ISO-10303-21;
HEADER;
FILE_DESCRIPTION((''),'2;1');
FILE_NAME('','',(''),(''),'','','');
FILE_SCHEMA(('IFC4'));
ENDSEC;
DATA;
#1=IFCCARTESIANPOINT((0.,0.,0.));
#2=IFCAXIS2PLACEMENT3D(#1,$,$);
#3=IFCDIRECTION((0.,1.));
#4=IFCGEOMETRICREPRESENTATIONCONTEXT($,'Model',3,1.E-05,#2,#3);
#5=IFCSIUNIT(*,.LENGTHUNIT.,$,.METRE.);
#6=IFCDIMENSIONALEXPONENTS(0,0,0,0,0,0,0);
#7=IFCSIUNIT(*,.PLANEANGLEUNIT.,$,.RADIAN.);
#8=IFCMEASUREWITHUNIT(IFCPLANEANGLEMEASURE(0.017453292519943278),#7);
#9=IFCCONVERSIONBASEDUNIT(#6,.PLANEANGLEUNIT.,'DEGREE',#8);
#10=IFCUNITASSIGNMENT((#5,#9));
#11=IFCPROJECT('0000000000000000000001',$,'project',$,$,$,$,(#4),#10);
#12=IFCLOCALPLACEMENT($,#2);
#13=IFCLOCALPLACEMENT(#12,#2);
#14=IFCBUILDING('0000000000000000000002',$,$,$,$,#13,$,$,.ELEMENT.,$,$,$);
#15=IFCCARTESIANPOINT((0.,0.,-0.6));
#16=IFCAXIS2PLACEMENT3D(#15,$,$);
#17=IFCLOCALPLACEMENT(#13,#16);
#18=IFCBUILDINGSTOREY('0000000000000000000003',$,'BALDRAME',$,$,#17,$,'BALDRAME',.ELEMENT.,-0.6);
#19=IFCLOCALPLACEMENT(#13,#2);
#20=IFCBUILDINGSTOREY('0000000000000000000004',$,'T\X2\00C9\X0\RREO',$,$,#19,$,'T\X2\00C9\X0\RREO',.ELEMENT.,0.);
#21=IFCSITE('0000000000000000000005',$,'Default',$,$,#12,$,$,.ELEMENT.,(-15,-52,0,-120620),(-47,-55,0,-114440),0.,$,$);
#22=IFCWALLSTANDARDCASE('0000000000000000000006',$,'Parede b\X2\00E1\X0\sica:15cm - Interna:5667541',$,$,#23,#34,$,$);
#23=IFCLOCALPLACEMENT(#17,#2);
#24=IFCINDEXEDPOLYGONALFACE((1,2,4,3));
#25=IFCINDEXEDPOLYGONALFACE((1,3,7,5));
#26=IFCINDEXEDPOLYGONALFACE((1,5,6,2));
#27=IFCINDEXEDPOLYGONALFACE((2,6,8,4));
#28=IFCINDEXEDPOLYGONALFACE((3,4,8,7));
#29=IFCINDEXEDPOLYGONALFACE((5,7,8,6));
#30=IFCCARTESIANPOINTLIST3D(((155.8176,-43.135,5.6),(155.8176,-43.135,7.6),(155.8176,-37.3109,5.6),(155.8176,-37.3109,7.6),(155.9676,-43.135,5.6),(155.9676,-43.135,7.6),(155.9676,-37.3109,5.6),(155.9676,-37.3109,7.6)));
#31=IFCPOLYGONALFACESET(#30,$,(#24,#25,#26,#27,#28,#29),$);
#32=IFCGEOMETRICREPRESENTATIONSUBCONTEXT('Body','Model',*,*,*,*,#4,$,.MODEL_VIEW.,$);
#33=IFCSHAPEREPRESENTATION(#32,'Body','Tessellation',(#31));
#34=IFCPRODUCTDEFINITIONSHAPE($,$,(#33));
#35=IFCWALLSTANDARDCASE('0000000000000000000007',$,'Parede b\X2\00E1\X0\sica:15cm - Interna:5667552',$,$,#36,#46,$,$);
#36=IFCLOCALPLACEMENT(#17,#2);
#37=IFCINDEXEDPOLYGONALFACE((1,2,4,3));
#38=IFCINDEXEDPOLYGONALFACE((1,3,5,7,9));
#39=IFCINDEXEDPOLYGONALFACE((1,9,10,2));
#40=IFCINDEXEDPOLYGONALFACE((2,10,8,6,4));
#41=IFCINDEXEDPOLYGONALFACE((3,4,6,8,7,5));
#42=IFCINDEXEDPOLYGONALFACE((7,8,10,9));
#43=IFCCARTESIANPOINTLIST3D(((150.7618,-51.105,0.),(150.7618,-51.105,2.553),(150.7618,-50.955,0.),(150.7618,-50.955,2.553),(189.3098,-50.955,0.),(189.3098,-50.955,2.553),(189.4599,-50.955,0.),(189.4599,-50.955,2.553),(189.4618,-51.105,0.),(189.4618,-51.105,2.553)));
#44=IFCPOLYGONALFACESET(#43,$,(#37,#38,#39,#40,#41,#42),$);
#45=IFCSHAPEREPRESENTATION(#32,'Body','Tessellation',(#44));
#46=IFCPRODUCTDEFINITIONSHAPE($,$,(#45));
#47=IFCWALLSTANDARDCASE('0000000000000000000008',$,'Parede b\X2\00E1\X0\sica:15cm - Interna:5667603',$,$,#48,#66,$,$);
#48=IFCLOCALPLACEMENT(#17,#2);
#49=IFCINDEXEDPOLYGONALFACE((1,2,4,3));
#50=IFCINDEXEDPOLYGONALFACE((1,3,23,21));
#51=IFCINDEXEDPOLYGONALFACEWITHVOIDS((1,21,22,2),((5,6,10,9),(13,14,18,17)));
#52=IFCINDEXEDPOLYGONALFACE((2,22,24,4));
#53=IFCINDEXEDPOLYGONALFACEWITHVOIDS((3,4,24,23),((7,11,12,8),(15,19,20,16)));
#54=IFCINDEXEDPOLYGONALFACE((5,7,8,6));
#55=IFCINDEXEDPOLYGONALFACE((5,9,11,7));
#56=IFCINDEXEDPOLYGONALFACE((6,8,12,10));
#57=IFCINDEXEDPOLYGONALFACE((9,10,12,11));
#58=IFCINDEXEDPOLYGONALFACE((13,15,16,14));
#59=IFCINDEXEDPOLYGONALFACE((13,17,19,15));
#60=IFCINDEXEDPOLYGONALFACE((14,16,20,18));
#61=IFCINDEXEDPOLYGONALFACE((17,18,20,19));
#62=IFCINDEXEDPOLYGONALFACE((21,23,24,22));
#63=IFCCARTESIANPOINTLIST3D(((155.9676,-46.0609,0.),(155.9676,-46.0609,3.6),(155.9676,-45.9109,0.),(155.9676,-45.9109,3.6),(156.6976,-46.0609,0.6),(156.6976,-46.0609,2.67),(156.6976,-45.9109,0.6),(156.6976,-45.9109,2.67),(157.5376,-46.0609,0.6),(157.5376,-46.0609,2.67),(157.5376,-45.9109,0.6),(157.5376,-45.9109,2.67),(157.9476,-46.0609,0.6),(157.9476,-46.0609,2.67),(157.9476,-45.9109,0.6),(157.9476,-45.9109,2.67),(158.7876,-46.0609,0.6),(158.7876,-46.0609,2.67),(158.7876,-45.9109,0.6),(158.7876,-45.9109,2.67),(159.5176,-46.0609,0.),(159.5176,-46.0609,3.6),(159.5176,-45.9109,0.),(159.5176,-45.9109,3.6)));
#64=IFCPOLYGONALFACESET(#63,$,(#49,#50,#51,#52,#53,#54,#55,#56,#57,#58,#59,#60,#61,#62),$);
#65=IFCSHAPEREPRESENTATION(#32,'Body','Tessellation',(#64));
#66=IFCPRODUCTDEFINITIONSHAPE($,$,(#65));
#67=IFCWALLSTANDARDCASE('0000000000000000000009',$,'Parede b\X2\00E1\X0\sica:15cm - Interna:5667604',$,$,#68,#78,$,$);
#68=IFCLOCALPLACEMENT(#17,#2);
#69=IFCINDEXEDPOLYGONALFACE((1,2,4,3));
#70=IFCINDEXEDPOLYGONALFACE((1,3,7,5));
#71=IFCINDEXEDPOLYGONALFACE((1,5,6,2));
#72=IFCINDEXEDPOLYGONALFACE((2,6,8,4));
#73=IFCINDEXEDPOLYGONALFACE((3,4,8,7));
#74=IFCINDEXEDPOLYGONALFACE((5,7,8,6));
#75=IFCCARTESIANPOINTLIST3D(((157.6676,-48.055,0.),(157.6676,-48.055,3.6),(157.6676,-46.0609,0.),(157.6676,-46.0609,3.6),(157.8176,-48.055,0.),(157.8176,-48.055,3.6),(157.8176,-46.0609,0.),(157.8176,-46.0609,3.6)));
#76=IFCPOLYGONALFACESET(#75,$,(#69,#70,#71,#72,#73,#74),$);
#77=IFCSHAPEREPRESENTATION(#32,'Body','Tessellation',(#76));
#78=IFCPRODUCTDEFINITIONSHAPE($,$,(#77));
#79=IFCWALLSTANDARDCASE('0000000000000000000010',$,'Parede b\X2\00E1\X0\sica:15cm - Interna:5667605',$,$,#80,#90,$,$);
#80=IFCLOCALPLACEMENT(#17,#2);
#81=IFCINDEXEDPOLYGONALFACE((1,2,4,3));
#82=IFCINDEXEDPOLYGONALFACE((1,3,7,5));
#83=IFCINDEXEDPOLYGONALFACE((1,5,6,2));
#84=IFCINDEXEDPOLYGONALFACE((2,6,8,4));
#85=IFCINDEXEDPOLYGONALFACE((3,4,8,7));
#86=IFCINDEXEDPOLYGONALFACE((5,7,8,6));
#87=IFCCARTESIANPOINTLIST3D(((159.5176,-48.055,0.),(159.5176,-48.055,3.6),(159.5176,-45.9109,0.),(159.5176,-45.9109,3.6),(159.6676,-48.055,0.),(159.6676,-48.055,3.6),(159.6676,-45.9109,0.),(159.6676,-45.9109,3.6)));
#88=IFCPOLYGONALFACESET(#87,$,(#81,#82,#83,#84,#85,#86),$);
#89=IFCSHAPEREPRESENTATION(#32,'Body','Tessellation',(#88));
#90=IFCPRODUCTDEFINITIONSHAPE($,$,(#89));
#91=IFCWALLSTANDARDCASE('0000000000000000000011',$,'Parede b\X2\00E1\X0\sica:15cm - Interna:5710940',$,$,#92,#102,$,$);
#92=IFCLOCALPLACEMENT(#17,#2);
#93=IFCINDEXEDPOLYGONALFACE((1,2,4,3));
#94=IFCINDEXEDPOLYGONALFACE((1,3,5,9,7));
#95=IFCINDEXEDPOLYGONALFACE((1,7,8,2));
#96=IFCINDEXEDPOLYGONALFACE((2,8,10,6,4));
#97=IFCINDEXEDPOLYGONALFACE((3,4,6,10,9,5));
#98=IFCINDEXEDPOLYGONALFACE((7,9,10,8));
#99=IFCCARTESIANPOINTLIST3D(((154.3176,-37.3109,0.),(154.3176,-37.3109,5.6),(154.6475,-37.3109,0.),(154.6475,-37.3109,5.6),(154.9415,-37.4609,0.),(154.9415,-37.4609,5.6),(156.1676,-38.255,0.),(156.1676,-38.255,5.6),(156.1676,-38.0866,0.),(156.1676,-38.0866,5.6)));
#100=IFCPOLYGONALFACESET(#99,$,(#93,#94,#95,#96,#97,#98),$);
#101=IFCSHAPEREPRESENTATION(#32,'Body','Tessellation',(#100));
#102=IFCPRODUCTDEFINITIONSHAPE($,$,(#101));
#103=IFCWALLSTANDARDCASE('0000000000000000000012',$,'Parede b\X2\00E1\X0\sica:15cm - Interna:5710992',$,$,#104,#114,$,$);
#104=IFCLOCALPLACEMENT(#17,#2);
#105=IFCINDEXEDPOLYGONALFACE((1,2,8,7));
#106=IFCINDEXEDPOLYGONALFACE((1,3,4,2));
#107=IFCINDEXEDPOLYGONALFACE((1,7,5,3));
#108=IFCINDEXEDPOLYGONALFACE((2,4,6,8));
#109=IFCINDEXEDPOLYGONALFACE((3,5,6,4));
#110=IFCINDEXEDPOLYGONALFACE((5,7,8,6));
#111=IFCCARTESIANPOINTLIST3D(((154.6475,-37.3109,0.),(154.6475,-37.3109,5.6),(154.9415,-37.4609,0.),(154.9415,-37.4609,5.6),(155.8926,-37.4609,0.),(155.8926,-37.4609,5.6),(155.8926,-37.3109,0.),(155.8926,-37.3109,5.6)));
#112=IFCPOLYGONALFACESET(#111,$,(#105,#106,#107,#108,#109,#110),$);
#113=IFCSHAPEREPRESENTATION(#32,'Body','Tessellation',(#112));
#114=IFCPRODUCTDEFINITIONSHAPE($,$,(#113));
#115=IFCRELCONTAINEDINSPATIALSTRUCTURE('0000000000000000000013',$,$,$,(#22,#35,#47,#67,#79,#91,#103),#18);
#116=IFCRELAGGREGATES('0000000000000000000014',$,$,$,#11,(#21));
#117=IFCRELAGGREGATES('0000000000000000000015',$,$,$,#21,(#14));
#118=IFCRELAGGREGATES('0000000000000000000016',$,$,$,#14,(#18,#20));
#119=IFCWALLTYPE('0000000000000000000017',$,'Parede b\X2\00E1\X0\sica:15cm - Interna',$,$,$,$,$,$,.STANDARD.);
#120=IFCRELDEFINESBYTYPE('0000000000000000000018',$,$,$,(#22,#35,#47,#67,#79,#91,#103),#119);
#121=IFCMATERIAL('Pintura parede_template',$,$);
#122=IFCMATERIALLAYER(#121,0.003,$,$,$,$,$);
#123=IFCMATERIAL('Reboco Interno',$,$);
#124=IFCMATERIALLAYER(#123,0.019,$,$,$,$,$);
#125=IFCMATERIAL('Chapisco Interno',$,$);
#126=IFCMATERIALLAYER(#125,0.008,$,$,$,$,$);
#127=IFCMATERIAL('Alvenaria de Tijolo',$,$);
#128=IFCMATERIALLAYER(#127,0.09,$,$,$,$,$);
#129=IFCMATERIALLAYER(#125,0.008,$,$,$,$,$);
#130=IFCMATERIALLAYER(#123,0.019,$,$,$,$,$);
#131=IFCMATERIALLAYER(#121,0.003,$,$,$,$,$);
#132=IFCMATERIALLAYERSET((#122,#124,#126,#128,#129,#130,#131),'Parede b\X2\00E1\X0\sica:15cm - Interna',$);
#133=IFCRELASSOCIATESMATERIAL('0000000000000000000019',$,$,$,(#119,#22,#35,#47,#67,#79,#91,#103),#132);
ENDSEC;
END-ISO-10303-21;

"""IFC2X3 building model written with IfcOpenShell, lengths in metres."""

from ifc_helpers import new_model, entity, si_unit, converted_unit, direction, frame, frame_2d, origin, place, context, subcontext, project, spatial, polyline, rectangle, outline, extrude, material, layer, layer_set, layer_usage, type_object, element, save


model = new_model("IFC2X3")

# Units and contexts
model_context = context("Model", 3, precision=1e-05, world=origin(), true_north=direction((0.0, 1.0)))
body_context = subcontext(model_context, "Body", "Model", "MODEL_VIEW")
ifc_project = project(units=[si_unit("LENGTHUNIT", "METRE"), converted_unit("PLANEANGLEUNIT", "DEGREE", entity("IfcPlaneAngleMeasure", 0.017453292519943278), si_unit("PLANEANGLEUNIT", "RADIAN"), dimensions=[0, 0, 0, 0, 0, 0, 0])], contexts=[model_context])

# Site, building, storey
site_placement = place(None, origin())
site = spatial("IfcSite", under=ifc_project, at=site_placement, Name="Default", CompositionType="ELEMENT", RefLatitude=(-15, -52, 0, -120620), RefLongitude=(-47, -55, 0, -114440), RefElevation=0.0)
building_placement = place(site_placement, origin())
building = spatial("IfcBuilding", under=site, at=building_placement, CompositionType="ELEMENT")
storey_1_placement = place(building_placement, frame((0.0, 0.0, -0.6)))
storey_1 = spatial("IfcBuildingStorey", under=building, at=storey_1_placement, Name="BALDRAME", LongName="BALDRAME", CompositionType="ELEMENT", Elevation=-0.6)

# Wall
ifc_material_1 = material(Name="Pintura parede_template")
ifc_layer_1 = layer(ifc_material_1, 0.003)
ifc_material_2 = material(Name="Reboco Interno")
ifc_layer_2 = layer(ifc_material_2, 0.019)
ifc_material_3 = material(Name="Chapisco Interno")
ifc_layer_3 = layer(ifc_material_3, 0.008)
ifc_material_4 = material(Name="Alvenaria de Tijolo")
ifc_layer_4 = layer(ifc_material_4, 0.09)
ifc_layer_5 = layer(ifc_material_3, 0.008)
ifc_layer_6 = layer(ifc_material_2, 0.019)
ifc_layer_7 = layer(ifc_material_1, 0.003)
ifc_layer_set = layer_set([ifc_layer_1, ifc_layer_2, ifc_layer_3, ifc_layer_4, ifc_layer_5, ifc_layer_6, ifc_layer_7], Name="Parede básica:15cm - Interna")
ifc_layer_usage_1 = layer_usage(ifc_layer_set, "AXIS2", "NEGATIVE", 0.075)
wall_type = type_object("IfcWallType", Name="Parede básica:15cm - Interna", PredefinedType="STANDARD", material=ifc_layer_set)
wall_1_placement = place(storey_1_placement, frame((155.8926, -37.3109, 5.6), z_axis=(0.0, 0.0, 1.0), x_axis=(0.0, -1.0, 0.0)))
element("IfcWallStandardCase", 1, at=wall_1_placement, inside=storey_1, type_object=wall_type, material=ifc_layer_usage_1, Name="Parede básica:15cm - Interna:5667541", context=body_context, shape_type="SweptSolid", body=[
    extrude(rectangle(XDim=5.8241, YDim=0.15, at=frame_2d((2.9121, 0.0), x_axis=(-1.0, 0.0))), origin(), (0.0, 0.0, 1.0), 2.0),
])

# Shared definitions
storey_2_placement = place(building_placement, origin())
storey_2 = spatial("IfcBuildingStorey", under=building, at=storey_2_placement, Name="TÉRREO", LongName="TÉRREO", CompositionType="ELEMENT", Elevation=0.0)

# Wall
ifc_layer_usage_2 = layer_usage(ifc_layer_set, "AXIS2", "NEGATIVE", 0.075)
wall_2_placement = place(storey_1_placement, frame((150.7618, -51.03, 0.0)))
element("IfcWallStandardCase", 2, at=wall_2_placement, inside=storey_1, type_object=wall_type, material=ifc_layer_usage_2, Name="Parede básica:15cm - Interna:5667552", context=body_context, shape_type="SweptSolid", body=[
    extrude(outline(polyline([(38.7, -0.075), (38.698, 0.075), (38.548, 0.075), (0.0, 0.075), (0.0, -0.075), (38.7, -0.075)])), origin(), (0.0, 0.0, 1.0), 2.553),
])

# Wall, openings
ifc_layer_usage_3 = layer_usage(ifc_layer_set, "AXIS2", "NEGATIVE", 0.075)
wall_3_placement = place(storey_1_placement, frame((155.9676, -45.9859, 0.0)))
wall_3 = element("IfcWallStandardCase", 3, at=wall_3_placement, inside=storey_1, type_object=wall_type, material=ifc_layer_usage_3, Name="Parede básica:15cm - Interna:5667603", context=body_context, shape_type="SweptSolid", body=[
    extrude(rectangle(XDim=3.55, YDim=0.15, at=frame_2d((1.775, 0.0), x_axis=(-1.0, 0.0))), origin(), (0.0, 0.0, 1.0), 3.6),
])
opening_1_placement = place(wall_3_placement, frame((0.73, -0.075, 0.6)))
element("IfcOpeningElement", 4, at=opening_1_placement, cuts=wall_3, ObjectType="Opening", context=body_context, shape_type="SweptSolid", body=[
    extrude(rectangle(XDim=0.84, YDim=2.07, at=frame_2d((1.035, 0.42), x_axis=(0.0, -1.0))), frame((0.0, 0.0, 0.0), z_axis=(0.0, 1.0, 0.0), x_axis=(0.0, 0.0, 1.0)), (0.0, 0.0, 1.0), 0.15),
])
opening_2_placement = place(wall_3_placement, frame((1.98, -0.075, 0.6)))
element("IfcOpeningElement", 5, at=opening_2_placement, cuts=wall_3, ObjectType="Opening", context=body_context, shape_type="SweptSolid", body=[
    extrude(rectangle(XDim=0.84, YDim=2.07, at=frame_2d((1.035, 0.42), x_axis=(0.0, 1.0))), frame((0.0, 0.0, 0.0), z_axis=(0.0, 1.0, 0.0), x_axis=(0.0, 0.0, 1.0)), (0.0, 0.0, 1.0), 0.15),
])

# Walls
ifc_layer_usage_4 = layer_usage(ifc_layer_set, "AXIS2", "NEGATIVE", 0.075)
wall_4_placement = place(storey_1_placement, frame((157.7426, -46.0609, 0.0), z_axis=(0.0, 0.0, 1.0), x_axis=(0.0, -1.0, 0.0)))
element("IfcWallStandardCase", 6, at=wall_4_placement, inside=storey_1, type_object=wall_type, material=ifc_layer_usage_4, Name="Parede básica:15cm - Interna:5667604", context=body_context, shape_type="SweptSolid", body=[
    extrude(rectangle(XDim=1.9941, YDim=0.15, at=frame_2d((0.9971, 0.0), x_axis=(-1.0, 0.0))), origin(), (0.0, 0.0, 1.0), 3.6),
])
ifc_layer_usage_5 = layer_usage(ifc_layer_set, "AXIS2", "NEGATIVE", 0.075)
wall_5_placement = place(storey_1_placement, frame((159.5926, -45.9109, 0.0), z_axis=(0.0, 0.0, 1.0), x_axis=(0.0, -1.0, 0.0)))
element("IfcWallStandardCase", 7, at=wall_5_placement, inside=storey_1, type_object=wall_type, material=ifc_layer_usage_5, Name="Parede básica:15cm - Interna:5667605", context=body_context, shape_type="SweptSolid", body=[
    extrude(rectangle(XDim=2.1441, YDim=0.15, at=frame_2d((1.0721, 0.0), x_axis=(-1.0, 0.0))), origin(), (0.0, 0.0, 1.0), 3.6),
])

# Walls
ifc_layer_usage_6 = layer_usage(ifc_layer_set, "AXIS2", "NEGATIVE", 0.075)
wall_6_placement = place(storey_1_placement, frame((156.2017, -38.1882, 0.0), z_axis=(0.0, 0.0, 1.0), x_axis=(-0.89071, 0.454571, 0.0)))
element("IfcWallStandardCase", 8, at=wall_6_placement, inside=storey_1, type_object=wall_type, material=ifc_layer_usage_6, Name="Parede básica:15cm - Interna:5710940", context=body_context, shape_type="SweptSolid", body=[
    extrude(outline(polyline([(1.7831, -0.075), (2.077, 0.075), (0.0, 0.075), (0.0766, -0.075), (1.4531, -0.075), (1.7831, -0.075)])), origin(), (0.0, 0.0, 1.0), 5.6),
])
ifc_layer_usage_7 = layer_usage(ifc_layer_set, "AXIS2", "NEGATIVE", 0.075)
wall_7_placement = place(storey_1_placement, frame((154.6475, -37.3859, 0.0)))
element("IfcWallStandardCase", 9, at=wall_7_placement, inside=storey_1, type_object=wall_type, material=ifc_layer_usage_7, Name="Parede básica:15cm - Interna:5710992", context=body_context, shape_type="SweptSolid", body=[
    extrude(outline(polyline([(1.245, -0.075), (1.245, 0.075), (0.0, 0.075), (0.2939, -0.075), (1.245, -0.075)])), origin(), (0.0, 0.0, 1.0), 5.6),
])

save(model, "model.ifc")
